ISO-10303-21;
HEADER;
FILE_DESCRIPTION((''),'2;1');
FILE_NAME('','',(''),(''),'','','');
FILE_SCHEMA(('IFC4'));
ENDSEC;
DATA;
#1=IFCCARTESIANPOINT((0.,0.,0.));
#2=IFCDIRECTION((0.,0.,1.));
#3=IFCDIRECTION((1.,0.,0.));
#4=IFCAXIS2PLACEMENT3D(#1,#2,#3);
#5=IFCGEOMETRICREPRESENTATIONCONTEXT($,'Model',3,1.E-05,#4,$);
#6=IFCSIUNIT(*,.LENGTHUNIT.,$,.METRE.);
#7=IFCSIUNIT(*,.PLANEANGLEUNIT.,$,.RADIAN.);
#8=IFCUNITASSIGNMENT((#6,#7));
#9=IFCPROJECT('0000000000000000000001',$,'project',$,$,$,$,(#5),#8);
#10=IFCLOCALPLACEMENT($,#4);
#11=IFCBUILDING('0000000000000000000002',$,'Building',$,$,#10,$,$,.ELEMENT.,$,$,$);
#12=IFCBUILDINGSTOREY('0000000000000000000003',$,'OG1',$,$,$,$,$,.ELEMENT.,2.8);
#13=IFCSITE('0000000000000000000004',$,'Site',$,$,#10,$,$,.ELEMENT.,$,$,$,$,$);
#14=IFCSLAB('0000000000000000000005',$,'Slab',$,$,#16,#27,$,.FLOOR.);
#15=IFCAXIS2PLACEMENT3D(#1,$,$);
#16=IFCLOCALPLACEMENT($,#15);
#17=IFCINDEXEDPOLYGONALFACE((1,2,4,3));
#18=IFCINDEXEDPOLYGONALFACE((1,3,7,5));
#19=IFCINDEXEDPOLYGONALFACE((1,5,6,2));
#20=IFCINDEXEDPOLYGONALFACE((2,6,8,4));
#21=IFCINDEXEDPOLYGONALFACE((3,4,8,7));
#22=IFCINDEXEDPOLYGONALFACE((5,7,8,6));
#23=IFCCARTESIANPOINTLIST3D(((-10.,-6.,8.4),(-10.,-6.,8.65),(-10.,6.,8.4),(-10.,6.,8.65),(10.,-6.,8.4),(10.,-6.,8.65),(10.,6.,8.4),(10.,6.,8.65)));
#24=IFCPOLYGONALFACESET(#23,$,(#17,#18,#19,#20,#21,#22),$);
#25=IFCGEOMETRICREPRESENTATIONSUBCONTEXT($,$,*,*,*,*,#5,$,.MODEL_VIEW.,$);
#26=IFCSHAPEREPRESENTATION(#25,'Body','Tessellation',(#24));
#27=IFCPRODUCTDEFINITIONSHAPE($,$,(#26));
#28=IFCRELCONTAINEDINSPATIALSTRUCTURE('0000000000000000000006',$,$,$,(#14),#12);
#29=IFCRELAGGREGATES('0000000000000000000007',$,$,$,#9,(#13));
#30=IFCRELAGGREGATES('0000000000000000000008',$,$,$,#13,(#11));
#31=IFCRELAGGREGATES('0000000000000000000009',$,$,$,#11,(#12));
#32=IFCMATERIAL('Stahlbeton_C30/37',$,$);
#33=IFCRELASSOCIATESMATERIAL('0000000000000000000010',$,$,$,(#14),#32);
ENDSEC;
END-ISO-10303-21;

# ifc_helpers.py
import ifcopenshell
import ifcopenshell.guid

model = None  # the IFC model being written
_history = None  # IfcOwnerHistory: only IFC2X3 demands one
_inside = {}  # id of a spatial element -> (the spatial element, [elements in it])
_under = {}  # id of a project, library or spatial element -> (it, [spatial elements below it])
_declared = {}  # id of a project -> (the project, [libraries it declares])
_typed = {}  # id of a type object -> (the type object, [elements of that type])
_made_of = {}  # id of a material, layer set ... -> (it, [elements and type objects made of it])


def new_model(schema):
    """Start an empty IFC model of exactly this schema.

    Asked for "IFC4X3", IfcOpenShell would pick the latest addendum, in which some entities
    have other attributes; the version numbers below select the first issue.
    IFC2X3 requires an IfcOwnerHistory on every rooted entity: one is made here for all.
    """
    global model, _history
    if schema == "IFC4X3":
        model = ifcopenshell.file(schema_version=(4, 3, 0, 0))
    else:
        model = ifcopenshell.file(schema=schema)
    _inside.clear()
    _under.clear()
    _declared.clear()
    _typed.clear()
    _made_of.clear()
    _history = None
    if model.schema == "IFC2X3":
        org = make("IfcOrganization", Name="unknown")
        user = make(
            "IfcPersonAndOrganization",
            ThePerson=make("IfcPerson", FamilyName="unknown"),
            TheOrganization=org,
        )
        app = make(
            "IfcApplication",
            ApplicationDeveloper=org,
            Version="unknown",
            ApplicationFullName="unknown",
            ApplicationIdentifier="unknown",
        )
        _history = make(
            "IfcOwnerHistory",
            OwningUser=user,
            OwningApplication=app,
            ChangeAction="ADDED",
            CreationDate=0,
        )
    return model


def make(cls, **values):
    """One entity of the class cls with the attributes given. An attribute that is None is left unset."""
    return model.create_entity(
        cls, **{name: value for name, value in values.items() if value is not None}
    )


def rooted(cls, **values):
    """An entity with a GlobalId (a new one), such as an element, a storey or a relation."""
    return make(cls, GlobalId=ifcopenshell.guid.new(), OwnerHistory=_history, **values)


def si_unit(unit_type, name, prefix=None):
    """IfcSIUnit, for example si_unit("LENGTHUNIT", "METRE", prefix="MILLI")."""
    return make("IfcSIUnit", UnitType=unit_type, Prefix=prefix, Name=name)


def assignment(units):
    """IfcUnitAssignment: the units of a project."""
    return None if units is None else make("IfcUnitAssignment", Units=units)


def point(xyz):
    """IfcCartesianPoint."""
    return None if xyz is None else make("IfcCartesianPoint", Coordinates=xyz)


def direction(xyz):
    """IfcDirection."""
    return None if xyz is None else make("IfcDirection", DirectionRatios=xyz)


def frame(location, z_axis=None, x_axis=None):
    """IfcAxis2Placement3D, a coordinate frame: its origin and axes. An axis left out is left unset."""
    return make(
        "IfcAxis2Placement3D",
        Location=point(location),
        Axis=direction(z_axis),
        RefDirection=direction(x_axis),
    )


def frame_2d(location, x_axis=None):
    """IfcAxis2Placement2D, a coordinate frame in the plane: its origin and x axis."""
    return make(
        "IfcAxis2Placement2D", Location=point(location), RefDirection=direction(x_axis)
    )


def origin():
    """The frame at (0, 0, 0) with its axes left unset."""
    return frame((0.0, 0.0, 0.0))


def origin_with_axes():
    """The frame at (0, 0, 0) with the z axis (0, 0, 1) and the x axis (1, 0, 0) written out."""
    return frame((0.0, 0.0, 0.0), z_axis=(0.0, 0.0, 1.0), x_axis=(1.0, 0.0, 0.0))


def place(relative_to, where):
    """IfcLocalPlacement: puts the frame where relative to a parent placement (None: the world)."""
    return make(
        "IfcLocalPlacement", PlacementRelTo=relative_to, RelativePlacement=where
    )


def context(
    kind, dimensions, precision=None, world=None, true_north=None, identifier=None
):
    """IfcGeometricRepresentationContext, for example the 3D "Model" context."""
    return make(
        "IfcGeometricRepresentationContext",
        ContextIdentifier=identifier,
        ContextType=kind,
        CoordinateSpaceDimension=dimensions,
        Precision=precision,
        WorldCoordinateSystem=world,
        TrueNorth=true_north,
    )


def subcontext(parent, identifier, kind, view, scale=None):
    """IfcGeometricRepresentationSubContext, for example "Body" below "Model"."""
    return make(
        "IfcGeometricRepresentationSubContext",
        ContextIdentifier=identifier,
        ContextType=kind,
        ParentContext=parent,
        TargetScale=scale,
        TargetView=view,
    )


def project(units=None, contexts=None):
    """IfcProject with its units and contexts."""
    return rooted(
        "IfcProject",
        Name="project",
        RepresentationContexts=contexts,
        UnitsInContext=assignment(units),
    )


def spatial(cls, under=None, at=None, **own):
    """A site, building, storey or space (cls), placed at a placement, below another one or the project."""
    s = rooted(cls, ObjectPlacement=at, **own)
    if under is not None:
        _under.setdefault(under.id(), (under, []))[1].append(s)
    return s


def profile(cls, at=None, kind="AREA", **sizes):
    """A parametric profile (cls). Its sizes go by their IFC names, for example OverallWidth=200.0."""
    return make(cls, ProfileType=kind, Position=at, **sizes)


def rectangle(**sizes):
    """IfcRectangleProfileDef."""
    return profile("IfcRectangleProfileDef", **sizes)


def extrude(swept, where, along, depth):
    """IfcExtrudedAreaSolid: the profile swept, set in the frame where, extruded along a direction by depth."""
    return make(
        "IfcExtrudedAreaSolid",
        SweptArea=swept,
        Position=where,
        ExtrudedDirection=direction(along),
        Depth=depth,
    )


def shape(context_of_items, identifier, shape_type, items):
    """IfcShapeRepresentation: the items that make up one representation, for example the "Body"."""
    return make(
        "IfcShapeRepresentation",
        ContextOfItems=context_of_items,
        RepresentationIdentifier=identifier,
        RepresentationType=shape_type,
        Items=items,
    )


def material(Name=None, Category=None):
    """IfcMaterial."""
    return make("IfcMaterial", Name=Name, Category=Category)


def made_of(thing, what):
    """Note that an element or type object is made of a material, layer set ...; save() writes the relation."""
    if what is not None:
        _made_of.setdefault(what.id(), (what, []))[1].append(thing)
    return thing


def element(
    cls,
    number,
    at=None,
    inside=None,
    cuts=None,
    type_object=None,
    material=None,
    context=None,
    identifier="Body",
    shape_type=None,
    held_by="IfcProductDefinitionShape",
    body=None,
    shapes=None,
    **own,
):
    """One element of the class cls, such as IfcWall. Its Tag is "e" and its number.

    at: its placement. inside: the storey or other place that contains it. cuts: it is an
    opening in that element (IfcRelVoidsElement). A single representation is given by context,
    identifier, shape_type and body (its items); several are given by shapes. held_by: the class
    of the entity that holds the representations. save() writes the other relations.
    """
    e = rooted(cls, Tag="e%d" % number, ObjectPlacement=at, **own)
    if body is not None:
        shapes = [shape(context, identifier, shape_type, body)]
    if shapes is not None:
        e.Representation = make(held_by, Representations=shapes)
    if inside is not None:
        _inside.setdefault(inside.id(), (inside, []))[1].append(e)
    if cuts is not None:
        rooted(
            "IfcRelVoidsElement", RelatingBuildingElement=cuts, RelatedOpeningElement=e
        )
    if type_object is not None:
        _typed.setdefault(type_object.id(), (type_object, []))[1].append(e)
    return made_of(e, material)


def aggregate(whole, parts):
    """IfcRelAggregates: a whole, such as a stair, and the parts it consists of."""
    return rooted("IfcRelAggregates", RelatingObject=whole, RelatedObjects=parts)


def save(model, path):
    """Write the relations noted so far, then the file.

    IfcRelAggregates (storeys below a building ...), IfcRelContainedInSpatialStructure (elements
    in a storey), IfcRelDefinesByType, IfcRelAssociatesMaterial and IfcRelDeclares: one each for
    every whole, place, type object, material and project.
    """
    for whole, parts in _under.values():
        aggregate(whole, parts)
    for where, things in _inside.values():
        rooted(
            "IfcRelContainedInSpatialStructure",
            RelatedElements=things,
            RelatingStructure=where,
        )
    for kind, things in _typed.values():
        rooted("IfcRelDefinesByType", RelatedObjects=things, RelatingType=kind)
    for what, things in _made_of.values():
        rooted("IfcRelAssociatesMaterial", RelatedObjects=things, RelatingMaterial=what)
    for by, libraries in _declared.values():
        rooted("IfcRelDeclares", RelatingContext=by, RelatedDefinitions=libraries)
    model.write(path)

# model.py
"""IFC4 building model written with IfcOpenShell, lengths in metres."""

from ifc_helpers import new_model, si_unit, frame, frame_2d, origin, origin_with_axes, place, context, subcontext, project, spatial, rectangle, extrude, material, element, save


model = new_model("IFC4")

# Units and contexts
model_context = context("Model", 3, precision=1e-05, world=origin_with_axes())
sub_context = subcontext(model_context, None, None, "MODEL_VIEW")
ifc_project = project(units=[si_unit("LENGTHUNIT", "METRE"), si_unit("PLANEANGLEUNIT", "RADIAN")], contexts=[model_context])

# Site, building, storey
placement_1 = place(None, origin_with_axes())
site = spatial("IfcSite", under=ifc_project, at=placement_1, Name="Site", CompositionType="ELEMENT")
building = spatial("IfcBuilding", under=site, at=placement_1, Name="Building", CompositionType="ELEMENT")
storey = spatial("IfcBuildingStorey", under=building, Name="OG1", CompositionType="ELEMENT", Elevation=2.8)

# Slab
ifc_material = material(Name="Stahlbeton_C30/37")
placement_2 = place(None, origin_with_axes())
placement_3 = place(placement_2, frame((0.0, 0.0, 2.8)))
slab_placement = place(placement_3, frame((-10.0, -6.0, 5.6)))
element("IfcSlab", 1, at=slab_placement, inside=storey, material=ifc_material, Name="Slab", PredefinedType="FLOOR", context=sub_context, shape_type="SweptSolid", body=[
    extrude(rectangle(XDim=20.0, YDim=12.0, at=frame_2d((10.0, 6.0))), origin(), (0.0, 0.0, 1.0), 0.25),
])

save(model, "model.ifc")
